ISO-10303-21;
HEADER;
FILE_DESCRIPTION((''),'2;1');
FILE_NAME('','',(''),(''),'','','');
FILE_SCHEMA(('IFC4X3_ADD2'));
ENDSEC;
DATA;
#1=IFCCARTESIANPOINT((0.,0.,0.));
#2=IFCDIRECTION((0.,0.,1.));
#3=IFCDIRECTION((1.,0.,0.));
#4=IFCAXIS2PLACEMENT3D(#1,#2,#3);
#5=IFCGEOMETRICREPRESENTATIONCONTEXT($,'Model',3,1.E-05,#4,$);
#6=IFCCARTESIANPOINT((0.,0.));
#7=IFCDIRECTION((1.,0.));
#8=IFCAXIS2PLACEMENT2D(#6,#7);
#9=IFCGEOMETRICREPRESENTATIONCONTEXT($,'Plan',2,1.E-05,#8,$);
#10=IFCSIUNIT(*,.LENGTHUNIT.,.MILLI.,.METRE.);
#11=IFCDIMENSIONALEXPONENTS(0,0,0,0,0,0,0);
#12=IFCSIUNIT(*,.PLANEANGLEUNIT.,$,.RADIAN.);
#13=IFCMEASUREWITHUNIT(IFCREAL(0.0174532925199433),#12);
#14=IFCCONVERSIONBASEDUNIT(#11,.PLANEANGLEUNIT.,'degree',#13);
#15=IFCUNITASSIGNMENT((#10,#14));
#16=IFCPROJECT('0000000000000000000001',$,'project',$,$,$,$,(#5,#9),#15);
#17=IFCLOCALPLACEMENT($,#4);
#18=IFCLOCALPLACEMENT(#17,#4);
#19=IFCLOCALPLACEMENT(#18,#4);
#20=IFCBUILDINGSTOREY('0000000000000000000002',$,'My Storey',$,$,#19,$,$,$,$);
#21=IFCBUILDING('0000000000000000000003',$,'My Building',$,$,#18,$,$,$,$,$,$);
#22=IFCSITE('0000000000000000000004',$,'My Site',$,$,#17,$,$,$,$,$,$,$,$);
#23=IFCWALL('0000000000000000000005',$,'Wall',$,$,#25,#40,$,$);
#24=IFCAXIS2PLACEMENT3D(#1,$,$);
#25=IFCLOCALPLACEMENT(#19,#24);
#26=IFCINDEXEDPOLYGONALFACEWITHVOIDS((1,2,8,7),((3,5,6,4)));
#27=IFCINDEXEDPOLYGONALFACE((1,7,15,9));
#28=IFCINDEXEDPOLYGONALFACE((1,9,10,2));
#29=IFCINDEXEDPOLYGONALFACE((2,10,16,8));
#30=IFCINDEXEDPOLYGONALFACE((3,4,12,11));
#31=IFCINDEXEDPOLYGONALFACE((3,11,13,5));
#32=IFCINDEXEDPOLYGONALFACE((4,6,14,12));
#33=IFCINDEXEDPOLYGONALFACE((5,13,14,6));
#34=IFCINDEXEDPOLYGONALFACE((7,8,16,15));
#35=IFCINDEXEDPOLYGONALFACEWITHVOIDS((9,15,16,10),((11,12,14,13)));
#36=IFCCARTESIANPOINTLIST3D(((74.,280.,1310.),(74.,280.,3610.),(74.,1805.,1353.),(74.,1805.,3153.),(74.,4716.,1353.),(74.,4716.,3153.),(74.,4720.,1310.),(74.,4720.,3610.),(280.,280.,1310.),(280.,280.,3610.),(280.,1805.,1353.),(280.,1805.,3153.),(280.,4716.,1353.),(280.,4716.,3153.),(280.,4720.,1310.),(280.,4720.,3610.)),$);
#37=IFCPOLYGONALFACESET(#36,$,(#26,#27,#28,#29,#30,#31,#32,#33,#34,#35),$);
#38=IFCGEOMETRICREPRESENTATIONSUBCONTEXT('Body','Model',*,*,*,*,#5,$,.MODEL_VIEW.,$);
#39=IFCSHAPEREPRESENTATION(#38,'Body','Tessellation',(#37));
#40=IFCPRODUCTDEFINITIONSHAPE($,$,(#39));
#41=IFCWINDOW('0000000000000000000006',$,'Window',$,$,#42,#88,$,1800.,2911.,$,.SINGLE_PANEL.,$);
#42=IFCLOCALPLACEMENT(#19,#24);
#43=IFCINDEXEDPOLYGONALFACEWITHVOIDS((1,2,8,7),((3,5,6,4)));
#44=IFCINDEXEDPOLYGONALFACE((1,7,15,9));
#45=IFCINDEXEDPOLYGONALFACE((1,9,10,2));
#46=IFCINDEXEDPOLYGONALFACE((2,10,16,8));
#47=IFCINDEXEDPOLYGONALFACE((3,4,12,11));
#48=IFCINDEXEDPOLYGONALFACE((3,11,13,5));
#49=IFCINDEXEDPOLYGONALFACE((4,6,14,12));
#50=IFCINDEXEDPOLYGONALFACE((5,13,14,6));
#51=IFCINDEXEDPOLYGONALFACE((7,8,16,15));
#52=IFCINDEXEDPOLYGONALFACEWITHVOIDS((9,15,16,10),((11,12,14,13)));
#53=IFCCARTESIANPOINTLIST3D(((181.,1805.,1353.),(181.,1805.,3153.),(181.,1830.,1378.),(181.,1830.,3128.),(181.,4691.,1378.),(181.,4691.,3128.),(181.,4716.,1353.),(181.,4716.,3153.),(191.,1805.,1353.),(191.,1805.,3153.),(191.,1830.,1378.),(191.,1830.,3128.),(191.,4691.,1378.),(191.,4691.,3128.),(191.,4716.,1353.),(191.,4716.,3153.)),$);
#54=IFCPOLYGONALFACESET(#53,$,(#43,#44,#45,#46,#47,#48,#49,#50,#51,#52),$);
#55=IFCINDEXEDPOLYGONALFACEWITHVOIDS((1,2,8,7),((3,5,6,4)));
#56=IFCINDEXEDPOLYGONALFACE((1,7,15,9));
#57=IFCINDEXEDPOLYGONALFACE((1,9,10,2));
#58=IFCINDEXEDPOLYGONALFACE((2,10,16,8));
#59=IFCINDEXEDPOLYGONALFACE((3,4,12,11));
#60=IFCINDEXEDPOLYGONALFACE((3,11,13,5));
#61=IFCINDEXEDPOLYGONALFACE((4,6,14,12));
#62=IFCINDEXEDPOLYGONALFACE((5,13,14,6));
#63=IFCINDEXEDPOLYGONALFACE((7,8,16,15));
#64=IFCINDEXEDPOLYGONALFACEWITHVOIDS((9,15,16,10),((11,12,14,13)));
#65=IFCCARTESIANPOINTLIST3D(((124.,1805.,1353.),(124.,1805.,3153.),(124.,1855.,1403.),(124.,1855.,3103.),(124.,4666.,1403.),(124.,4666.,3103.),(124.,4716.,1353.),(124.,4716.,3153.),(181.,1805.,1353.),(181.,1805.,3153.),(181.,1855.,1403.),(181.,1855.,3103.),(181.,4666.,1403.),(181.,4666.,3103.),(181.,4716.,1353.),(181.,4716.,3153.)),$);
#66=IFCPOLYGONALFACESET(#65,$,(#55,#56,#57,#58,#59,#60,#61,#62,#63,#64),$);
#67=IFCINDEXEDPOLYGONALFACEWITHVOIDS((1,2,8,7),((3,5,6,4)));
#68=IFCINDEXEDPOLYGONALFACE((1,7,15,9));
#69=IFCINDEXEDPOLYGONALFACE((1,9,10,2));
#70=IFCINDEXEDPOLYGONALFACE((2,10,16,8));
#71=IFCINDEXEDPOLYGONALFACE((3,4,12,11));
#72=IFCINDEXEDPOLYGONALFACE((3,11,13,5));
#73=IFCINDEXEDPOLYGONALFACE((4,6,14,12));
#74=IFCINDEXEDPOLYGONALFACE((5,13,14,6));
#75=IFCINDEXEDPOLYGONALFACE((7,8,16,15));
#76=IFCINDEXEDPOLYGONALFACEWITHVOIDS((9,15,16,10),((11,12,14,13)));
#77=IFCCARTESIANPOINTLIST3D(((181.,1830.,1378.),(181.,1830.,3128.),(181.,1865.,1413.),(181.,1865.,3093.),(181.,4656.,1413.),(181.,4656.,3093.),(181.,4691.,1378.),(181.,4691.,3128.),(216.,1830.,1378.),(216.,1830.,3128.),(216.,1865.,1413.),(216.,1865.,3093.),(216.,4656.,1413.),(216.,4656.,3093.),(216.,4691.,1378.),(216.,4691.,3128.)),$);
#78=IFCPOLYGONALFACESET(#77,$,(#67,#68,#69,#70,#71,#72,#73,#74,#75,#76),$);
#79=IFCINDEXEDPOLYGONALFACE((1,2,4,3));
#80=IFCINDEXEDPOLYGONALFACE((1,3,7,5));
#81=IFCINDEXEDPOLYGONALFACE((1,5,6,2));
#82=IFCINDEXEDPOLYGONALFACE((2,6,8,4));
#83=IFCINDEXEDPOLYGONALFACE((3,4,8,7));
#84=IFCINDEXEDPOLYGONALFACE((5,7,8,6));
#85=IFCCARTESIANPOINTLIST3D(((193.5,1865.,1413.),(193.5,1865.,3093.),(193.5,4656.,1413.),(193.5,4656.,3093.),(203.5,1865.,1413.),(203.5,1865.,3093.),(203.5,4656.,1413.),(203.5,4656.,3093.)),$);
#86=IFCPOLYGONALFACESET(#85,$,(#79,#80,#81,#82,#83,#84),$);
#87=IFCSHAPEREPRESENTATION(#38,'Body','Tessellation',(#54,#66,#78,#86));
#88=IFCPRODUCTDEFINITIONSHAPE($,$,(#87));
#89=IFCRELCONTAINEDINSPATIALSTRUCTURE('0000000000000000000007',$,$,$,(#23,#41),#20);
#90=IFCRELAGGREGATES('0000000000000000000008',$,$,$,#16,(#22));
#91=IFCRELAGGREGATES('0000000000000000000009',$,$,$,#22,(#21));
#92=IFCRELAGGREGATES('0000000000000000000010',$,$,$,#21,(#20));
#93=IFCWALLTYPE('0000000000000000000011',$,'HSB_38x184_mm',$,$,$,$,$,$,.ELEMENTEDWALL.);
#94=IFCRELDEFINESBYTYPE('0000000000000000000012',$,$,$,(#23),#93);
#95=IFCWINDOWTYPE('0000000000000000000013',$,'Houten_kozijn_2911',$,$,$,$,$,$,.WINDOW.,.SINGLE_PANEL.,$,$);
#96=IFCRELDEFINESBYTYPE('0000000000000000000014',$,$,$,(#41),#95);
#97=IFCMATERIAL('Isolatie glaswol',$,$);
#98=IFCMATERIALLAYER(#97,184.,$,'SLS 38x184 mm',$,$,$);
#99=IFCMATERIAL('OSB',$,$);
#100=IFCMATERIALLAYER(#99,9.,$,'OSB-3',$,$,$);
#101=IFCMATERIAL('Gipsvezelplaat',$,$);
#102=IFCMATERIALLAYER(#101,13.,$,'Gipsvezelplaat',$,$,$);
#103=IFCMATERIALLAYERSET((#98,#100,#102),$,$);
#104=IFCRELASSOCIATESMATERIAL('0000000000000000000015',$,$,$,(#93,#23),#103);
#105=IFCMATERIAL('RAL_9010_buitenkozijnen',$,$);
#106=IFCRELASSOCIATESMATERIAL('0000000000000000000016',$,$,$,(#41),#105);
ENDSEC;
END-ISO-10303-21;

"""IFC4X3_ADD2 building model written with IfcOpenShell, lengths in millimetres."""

from ifc_helpers import new_model, entity, si_unit, converted_unit, frame, origin_with_axes, origin_2d_with_axis, place, context, subcontext, project, spatial, line, indexed_curve, outline, extrude, shape, source, transform, mapped, material, layer, layer_set, layer_usage, type_object, type_shapes, element, fill, save


model = new_model("IFC4X3_ADD2")

# Units and contexts
model_context = context("Model", 3, precision=1e-05, world=origin_with_axes())
plan_context = context("Plan", 2, precision=1e-05, world=origin_2d_with_axis())
body_context_1 = subcontext(model_context, "Body", "Model", "MODEL_VIEW")
body_context_2 = subcontext(plan_context, "Body", "Plan", "PLAN_VIEW")
ifc_project = project(units=[si_unit("LENGTHUNIT", "METRE", prefix="MILLI"), converted_unit("PLANEANGLEUNIT", "degree", entity("IfcReal", 0.0174532925199433), si_unit("PLANEANGLEUNIT", "RADIAN"), dimensions=[0, 0, 0, 0, 0, 0, 0])], contexts=[model_context, plan_context])

# Site, building, storey
site_placement = place(None, origin_with_axes())
site = spatial("IfcSite", under=ifc_project, at=site_placement, Name="My Site")
building_placement = place(site_placement, origin_with_axes())
building = spatial("IfcBuilding", under=site, at=building_placement, Name="My Building")
storey_placement = place(building_placement, origin_with_axes())
storey = spatial("IfcBuildingStorey", under=building, at=storey_placement, Name="My Storey")

# Shared definitions
ifc_material_1 = material(Name="Isolatie glaswol")

# Wall, opening, window
ifc_layer_1 = layer(ifc_material_1, 184.0, Name="SLS 38x184 mm")
ifc_material_2 = material(Name="OSB")
ifc_layer_2 = layer(ifc_material_2, 9.0, Name="OSB-3")
ifc_material_3 = material(Name="Gipsvezelplaat")
ifc_layer_3 = layer(ifc_material_3, 13.0, Name="Gipsvezelplaat")
ifc_layer_set_1 = layer_set([ifc_layer_1, ifc_layer_2, ifc_layer_3])
wall_type_1 = type_object("IfcWallType", Name="HSB_38x184_mm", PredefinedType="ELEMENTEDWALL", material=ifc_layer_set_1)
ifc_material_4 = material(Name="RAL_9010_buitenkozijnen")
ifc_layer_usage_1 = layer_usage(ifc_layer_set_1, "AXIS2", "POSITIVE", 0.0)
wall_1_placement = place(storey_placement, frame((74.0, 4720.0, 1310.0), z_axis=(0.0, 0.0, 1.0), x_axis=(0.0, -1.0, 0.0)))
wall_1 = element("IfcWall", 1, at=wall_1_placement, inside=storey, type_object=wall_type_1, material=ifc_layer_usage_1, Name="Wall", context=body_context_1, shape_type="SweptSolid", body=[
    extrude(outline(indexed_curve([(0.0, 0.0), (0.0, 206.0), (4440.0, 206.0), (4440.0, 0.0), (0.0, 0.0)], self_intersect=False)), origin_with_axes(), (0.0, 0.0, 1.0), 2300.0),
])
shared_shape_1 = source(origin_with_axes(), body_context_1, "Body", "SweptSolid", [
    extrude(outline(indexed_curve([(0.0, 0.0), (2911.0, 0.0), (2911.0, 1800.0), (0.0, 1800.0)], segments=[line(1, 2, 3, 4, 1)])), frame((0.0, -600.0, 0.0), z_axis=(0.0, -1.0, 0.0), x_axis=(1.0, 0.0, 0.0)), (0.0, 0.0, -1.0), 1200.0),
])
opening_1_placement = place(wall_1_placement, frame((4.0, 0.0, 43.0), z_axis=(0.0, 0.0, 1.0), x_axis=(1.0, 0.0, 0.0)))
opening_1 = element("IfcOpeningElement", 2, at=opening_1_placement, cuts=wall_1, PredefinedType="OPENING", context=body_context_1, shape_type="MappedRepresentation", body=[
    mapped(shared_shape_1, transform((0.0, 0.0, 0.0), x_axis=(1.0, 0.0, 0.0), y_axis=(0.0, 1.0, 0.0), z_axis=(0.0, 0.0, 1.0), scale=1.0)),
])
window_type_1 = type_object("IfcWindowType", Name="Houten_kozijn_2911", PartitioningType="SINGLE_PANEL", PredefinedType="WINDOW")
shared_shape_2 = source(origin_with_axes(), body_context_1, "Body", "SweptSolid", [
    extrude(outline(indexed_curve([(0.0, 0.0), (2911.0, 0.0), (2911.0, 1800.0), (0.0, 1800.0)], segments=[line(1, 2, 3, 4, 1)]), holes=[indexed_curve([(25.0, 25.0), (2886.0, 25.0), (2886.0, 1775.0), (25.0, 1775.0)], segments=[line(1, 2, 3, 4, 1)])]), frame((0.0, 107.0, 0.0), z_axis=(0.0, -1.0, 0.0), x_axis=(1.0, 0.0, 0.0)), (0.0, 0.0, -1.0), 10.0),
    extrude(outline(indexed_curve([(0.0, 0.0), (2911.0, 0.0), (2911.0, 1800.0), (0.0, 1800.0)], segments=[line(1, 2, 3, 4, 1)]), holes=[indexed_curve([(50.0, 50.0), (2861.0, 50.0), (2861.0, 1750.0), (50.0, 1750.0)], segments=[line(1, 2, 3, 4, 1)])]), frame((0.0, 50.0, 0.0), z_axis=(0.0, -1.0, 0.0), x_axis=(1.0, 0.0, 0.0)), (0.0, 0.0, -1.0), 57.0),
    extrude(outline(indexed_curve([(0.0, 0.0), (2861.0, 0.0), (2861.0, 1750.0), (0.0, 1750.0)], segments=[line(1, 2, 3, 4, 1)]), holes=[indexed_curve([(35.0, 35.0), (2826.0, 35.0), (2826.0, 1715.0), (35.0, 1715.0)], segments=[line(1, 2, 3, 4, 1)])]), frame((25.0, 107.0, 25.0), z_axis=(0.0, -1.0, 0.0), x_axis=(1.0, 0.0, 0.0)), (0.0, 0.0, -1.0), 35.0),
    extrude(outline(indexed_curve([(35.0, 35.0), (2826.0, 35.0), (2826.0, 1715.0), (35.0, 1715.0)], segments=[line(1, 2, 3, 4, 1)])), frame((25.0, 119.5, 25.0), z_axis=(0.0, -1.0, 0.0), x_axis=(1.0, 0.0, 0.0)), (0.0, 0.0, -1.0), 10.0),
])
shared_shape_3 = source(origin_with_axes(), body_context_2, "Body", "Curve2D", [
    entity("IfcIndexedPolyCurve", entity("IfcCartesianPointList2D", [[50.0, 50.0], [2861.0, 50.0]])),
    entity("IfcIndexedPolyCurve", entity("IfcCartesianPointList2D", [[0.0, 117.0], [25.0, 117.0], [25.0, 107.0], [50.0, 107.0], [50.0, 50.0], [0.0, 50.0]]), [entity("IfcLineIndex", [1, 2, 3, 4, 5, 6, 1])]),
    entity("IfcIndexedPolyCurve", entity("IfcCartesianPointList2D", [[2911.0, 117.0], [2886.0, 117.0], [2886.0, 107.0], [2861.0, 107.0], [2861.0, 50.0], [2911.0, 50.0]]), [entity("IfcLineIndex", [1, 2, 3, 4, 5, 6, 1])]),
    entity("IfcIndexedPolyCurve", entity("IfcCartesianPointList2D", [[25.0, 107.0], [60.0, 107.0], [60.0, 142.0], [25.0, 142.0]]), [entity("IfcLineIndex", [1, 2, 3, 4, 1])]),
    entity("IfcIndexedPolyCurve", entity("IfcCartesianPointList2D", [[2886.0, 107.0], [2851.0, 107.0], [2851.0, 142.0], [2886.0, 142.0]]), [entity("IfcLineIndex", [1, 2, 3, 4, 1])]),
    entity("IfcIndexedPolyCurve", entity("IfcCartesianPointList2D", [[60.0, 107.0], [2851.0, 107.0]])),
    entity("IfcIndexedPolyCurve", entity("IfcCartesianPointList2D", [[60.0, 142.0], [2851.0, 142.0]])),
    entity("IfcIndexedPolyCurve", entity("IfcCartesianPointList2D", [[60.0, 124.5], [2851.0, 124.5]])),
])
type_shapes(window_type_1, [shared_shape_2, shared_shape_3])
window_1_placement = place(opening_1_placement, frame((0.0, 0.0, 0.0), z_axis=(0.0, 0.0, 1.0), x_axis=(1.0, 0.0, 0.0)))
window_1 = element("IfcWindow", 3, at=window_1_placement, inside=storey, type_object=window_type_1, material=ifc_material_4, Name="Window", OverallHeight=1800.0, OverallWidth=2911.0, PartitioningType="SINGLE_PANEL", shapes=[
    shape(body_context_1, "Body", "MappedRepresentation", [mapped(shared_shape_2, transform((0.0, 0.0, 0.0), x_axis=(1.0, 0.0, 0.0), y_axis=(0.0, 1.0, 0.0), z_axis=(0.0, 0.0, 1.0), scale=1.0))]),
    shape(body_context_2, "Body", "MappedRepresentation", [mapped(shared_shape_3, transform((0.0, 0.0, 0.0), x_axis=(1.0, 0.0, 0.0), y_axis=(0.0, 1.0, 0.0), z_axis=(0.0, 0.0, 1.0), scale=1.0))]),
])
fill(opening_1, window_1)

save(model, "model.ifc")
